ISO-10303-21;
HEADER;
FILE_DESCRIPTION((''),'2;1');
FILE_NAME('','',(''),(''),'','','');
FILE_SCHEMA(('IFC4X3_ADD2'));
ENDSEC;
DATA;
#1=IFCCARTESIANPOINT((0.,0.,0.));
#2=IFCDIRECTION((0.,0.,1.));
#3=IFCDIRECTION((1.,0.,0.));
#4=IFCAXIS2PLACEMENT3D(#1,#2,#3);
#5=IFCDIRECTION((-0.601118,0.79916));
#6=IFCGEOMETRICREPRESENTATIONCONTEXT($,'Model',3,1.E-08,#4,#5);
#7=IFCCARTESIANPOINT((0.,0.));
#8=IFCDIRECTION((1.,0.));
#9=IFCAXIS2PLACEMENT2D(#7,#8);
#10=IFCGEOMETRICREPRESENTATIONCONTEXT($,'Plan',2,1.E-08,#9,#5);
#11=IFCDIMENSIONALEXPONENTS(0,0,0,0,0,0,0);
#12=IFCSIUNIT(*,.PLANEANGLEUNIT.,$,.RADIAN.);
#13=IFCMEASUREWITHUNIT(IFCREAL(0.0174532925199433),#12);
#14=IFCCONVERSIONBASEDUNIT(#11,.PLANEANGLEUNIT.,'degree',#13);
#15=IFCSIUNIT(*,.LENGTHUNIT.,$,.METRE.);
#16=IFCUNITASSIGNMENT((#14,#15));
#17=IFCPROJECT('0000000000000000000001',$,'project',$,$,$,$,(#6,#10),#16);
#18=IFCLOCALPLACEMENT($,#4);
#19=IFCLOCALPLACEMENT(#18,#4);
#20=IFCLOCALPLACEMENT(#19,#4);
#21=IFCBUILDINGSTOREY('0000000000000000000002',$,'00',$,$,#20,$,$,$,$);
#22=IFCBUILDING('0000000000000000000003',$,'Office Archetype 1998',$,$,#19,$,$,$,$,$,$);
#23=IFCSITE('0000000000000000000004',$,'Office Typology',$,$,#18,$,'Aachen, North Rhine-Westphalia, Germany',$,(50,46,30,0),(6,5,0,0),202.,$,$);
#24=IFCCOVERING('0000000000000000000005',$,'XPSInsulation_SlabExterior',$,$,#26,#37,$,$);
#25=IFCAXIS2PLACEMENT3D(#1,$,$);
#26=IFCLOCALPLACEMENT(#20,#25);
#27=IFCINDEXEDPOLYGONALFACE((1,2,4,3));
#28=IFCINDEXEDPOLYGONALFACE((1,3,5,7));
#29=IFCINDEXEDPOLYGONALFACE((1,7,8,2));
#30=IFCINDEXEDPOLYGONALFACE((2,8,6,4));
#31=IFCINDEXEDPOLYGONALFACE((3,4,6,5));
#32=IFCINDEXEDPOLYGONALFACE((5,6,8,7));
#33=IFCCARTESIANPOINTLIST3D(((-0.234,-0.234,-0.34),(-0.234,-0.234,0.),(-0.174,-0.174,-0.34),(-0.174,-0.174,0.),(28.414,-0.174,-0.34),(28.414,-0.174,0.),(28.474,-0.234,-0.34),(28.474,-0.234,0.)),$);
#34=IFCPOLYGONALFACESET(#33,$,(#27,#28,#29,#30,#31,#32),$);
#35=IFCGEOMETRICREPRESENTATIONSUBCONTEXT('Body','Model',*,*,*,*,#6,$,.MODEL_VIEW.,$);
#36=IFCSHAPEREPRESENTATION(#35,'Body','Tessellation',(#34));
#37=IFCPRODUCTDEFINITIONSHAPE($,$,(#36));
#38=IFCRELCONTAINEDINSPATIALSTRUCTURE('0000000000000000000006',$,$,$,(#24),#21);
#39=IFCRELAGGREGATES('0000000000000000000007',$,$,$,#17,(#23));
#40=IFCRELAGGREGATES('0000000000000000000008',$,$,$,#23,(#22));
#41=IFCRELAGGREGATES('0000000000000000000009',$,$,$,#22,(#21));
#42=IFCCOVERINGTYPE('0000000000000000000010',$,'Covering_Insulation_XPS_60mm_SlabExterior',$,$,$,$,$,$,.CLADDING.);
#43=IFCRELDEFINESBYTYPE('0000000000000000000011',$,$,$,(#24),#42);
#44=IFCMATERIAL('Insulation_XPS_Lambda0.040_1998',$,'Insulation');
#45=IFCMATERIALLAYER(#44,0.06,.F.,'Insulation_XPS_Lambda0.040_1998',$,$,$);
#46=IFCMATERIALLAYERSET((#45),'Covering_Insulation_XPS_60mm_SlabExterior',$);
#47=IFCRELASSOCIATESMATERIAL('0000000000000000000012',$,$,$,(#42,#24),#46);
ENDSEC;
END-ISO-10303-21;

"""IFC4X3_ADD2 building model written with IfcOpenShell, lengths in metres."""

from ifc_helpers import new_model, entity, si_unit, converted_unit, direction, frame, origin_with_axes, origin_2d_with_axis, place, context, subcontext, project, spatial, line, indexed_curve, outline, extrude, material, layer, layer_set, layer_usage, type_object, element, save


model = new_model("IFC4X3_ADD2")

# Units and contexts
model_context = context("Model", 3, precision=1e-08, world=origin_with_axes(), true_north=direction((-0.601118, 0.79916)))
plan_context = context("Plan", 2, precision=1e-08, world=origin_2d_with_axis(), true_north=direction((-0.601118, 0.79916)))
body_context = subcontext(model_context, "Body", "Model", "MODEL_VIEW")
ifc_project = project(units=[converted_unit("PLANEANGLEUNIT", "degree", entity("IfcReal", 0.0174532925199433), si_unit("PLANEANGLEUNIT", "RADIAN"), dimensions=[0, 0, 0, 0, 0, 0, 0]), si_unit("LENGTHUNIT", "METRE")], contexts=[model_context, plan_context])

# Site, building, storey
site_placement = place(None, origin_with_axes())
site = spatial("IfcSite", under=ifc_project, at=site_placement, Name="Office Typology", LongName="Aachen, North Rhine-Westphalia, Germany", RefLatitude=(50, 46, 30, 0), RefLongitude=(6, 5, 0, 0), RefElevation=202.0)
building_placement = place(site_placement, origin_with_axes())
building = spatial("IfcBuilding", under=site, at=building_placement, Name="Office Archetype 1998")
storey_placement = place(building_placement, origin_with_axes())
storey = spatial("IfcBuildingStorey", under=building, at=storey_placement, Name="00")

# Shared definitions
ifc_material_1 = material(Name="Insulation_XPS_Lambda0.040_1998", Category="Insulation")

# Covering
ifc_layer_1 = layer(ifc_material_1, 0.06, ventilated=False, Name="Insulation_XPS_Lambda0.040_1998")
ifc_layer_set_1 = layer_set([ifc_layer_1], Name="Covering_Insulation_XPS_60mm_SlabExterior")
ifc_layer_usage_1 = layer_usage(ifc_layer_set_1, "AXIS2", "POSITIVE", 0.0)
covering_type_1 = type_object("IfcCoveringType", Name="Covering_Insulation_XPS_60mm_SlabExterior", PredefinedType="CLADDING", material=ifc_layer_set_1)
covering_1_placement = place(storey_placement, frame((-0.234, -0.234, -0.34), z_axis=(0.0, 0.0, 1.0), x_axis=(1.0, 0.0, 0.0)))
element("IfcCovering", 1, at=covering_1_placement, inside=storey, type_object=covering_type_1, material=ifc_layer_usage_1, Name="XPSInsulation_SlabExterior", context=body_context, shape_type="SweptSolid", body=[
    extrude(outline(indexed_curve([(0.0, 0.0), (0.06, 0.06), (28.648, 0.06), (28.708, 0.0)], segments=[line(1, 2, 3, 4, 1)])), origin_with_axes(), (0.0, 0.0, 1.0), 0.34),
])

save(model, "model.ifc")
